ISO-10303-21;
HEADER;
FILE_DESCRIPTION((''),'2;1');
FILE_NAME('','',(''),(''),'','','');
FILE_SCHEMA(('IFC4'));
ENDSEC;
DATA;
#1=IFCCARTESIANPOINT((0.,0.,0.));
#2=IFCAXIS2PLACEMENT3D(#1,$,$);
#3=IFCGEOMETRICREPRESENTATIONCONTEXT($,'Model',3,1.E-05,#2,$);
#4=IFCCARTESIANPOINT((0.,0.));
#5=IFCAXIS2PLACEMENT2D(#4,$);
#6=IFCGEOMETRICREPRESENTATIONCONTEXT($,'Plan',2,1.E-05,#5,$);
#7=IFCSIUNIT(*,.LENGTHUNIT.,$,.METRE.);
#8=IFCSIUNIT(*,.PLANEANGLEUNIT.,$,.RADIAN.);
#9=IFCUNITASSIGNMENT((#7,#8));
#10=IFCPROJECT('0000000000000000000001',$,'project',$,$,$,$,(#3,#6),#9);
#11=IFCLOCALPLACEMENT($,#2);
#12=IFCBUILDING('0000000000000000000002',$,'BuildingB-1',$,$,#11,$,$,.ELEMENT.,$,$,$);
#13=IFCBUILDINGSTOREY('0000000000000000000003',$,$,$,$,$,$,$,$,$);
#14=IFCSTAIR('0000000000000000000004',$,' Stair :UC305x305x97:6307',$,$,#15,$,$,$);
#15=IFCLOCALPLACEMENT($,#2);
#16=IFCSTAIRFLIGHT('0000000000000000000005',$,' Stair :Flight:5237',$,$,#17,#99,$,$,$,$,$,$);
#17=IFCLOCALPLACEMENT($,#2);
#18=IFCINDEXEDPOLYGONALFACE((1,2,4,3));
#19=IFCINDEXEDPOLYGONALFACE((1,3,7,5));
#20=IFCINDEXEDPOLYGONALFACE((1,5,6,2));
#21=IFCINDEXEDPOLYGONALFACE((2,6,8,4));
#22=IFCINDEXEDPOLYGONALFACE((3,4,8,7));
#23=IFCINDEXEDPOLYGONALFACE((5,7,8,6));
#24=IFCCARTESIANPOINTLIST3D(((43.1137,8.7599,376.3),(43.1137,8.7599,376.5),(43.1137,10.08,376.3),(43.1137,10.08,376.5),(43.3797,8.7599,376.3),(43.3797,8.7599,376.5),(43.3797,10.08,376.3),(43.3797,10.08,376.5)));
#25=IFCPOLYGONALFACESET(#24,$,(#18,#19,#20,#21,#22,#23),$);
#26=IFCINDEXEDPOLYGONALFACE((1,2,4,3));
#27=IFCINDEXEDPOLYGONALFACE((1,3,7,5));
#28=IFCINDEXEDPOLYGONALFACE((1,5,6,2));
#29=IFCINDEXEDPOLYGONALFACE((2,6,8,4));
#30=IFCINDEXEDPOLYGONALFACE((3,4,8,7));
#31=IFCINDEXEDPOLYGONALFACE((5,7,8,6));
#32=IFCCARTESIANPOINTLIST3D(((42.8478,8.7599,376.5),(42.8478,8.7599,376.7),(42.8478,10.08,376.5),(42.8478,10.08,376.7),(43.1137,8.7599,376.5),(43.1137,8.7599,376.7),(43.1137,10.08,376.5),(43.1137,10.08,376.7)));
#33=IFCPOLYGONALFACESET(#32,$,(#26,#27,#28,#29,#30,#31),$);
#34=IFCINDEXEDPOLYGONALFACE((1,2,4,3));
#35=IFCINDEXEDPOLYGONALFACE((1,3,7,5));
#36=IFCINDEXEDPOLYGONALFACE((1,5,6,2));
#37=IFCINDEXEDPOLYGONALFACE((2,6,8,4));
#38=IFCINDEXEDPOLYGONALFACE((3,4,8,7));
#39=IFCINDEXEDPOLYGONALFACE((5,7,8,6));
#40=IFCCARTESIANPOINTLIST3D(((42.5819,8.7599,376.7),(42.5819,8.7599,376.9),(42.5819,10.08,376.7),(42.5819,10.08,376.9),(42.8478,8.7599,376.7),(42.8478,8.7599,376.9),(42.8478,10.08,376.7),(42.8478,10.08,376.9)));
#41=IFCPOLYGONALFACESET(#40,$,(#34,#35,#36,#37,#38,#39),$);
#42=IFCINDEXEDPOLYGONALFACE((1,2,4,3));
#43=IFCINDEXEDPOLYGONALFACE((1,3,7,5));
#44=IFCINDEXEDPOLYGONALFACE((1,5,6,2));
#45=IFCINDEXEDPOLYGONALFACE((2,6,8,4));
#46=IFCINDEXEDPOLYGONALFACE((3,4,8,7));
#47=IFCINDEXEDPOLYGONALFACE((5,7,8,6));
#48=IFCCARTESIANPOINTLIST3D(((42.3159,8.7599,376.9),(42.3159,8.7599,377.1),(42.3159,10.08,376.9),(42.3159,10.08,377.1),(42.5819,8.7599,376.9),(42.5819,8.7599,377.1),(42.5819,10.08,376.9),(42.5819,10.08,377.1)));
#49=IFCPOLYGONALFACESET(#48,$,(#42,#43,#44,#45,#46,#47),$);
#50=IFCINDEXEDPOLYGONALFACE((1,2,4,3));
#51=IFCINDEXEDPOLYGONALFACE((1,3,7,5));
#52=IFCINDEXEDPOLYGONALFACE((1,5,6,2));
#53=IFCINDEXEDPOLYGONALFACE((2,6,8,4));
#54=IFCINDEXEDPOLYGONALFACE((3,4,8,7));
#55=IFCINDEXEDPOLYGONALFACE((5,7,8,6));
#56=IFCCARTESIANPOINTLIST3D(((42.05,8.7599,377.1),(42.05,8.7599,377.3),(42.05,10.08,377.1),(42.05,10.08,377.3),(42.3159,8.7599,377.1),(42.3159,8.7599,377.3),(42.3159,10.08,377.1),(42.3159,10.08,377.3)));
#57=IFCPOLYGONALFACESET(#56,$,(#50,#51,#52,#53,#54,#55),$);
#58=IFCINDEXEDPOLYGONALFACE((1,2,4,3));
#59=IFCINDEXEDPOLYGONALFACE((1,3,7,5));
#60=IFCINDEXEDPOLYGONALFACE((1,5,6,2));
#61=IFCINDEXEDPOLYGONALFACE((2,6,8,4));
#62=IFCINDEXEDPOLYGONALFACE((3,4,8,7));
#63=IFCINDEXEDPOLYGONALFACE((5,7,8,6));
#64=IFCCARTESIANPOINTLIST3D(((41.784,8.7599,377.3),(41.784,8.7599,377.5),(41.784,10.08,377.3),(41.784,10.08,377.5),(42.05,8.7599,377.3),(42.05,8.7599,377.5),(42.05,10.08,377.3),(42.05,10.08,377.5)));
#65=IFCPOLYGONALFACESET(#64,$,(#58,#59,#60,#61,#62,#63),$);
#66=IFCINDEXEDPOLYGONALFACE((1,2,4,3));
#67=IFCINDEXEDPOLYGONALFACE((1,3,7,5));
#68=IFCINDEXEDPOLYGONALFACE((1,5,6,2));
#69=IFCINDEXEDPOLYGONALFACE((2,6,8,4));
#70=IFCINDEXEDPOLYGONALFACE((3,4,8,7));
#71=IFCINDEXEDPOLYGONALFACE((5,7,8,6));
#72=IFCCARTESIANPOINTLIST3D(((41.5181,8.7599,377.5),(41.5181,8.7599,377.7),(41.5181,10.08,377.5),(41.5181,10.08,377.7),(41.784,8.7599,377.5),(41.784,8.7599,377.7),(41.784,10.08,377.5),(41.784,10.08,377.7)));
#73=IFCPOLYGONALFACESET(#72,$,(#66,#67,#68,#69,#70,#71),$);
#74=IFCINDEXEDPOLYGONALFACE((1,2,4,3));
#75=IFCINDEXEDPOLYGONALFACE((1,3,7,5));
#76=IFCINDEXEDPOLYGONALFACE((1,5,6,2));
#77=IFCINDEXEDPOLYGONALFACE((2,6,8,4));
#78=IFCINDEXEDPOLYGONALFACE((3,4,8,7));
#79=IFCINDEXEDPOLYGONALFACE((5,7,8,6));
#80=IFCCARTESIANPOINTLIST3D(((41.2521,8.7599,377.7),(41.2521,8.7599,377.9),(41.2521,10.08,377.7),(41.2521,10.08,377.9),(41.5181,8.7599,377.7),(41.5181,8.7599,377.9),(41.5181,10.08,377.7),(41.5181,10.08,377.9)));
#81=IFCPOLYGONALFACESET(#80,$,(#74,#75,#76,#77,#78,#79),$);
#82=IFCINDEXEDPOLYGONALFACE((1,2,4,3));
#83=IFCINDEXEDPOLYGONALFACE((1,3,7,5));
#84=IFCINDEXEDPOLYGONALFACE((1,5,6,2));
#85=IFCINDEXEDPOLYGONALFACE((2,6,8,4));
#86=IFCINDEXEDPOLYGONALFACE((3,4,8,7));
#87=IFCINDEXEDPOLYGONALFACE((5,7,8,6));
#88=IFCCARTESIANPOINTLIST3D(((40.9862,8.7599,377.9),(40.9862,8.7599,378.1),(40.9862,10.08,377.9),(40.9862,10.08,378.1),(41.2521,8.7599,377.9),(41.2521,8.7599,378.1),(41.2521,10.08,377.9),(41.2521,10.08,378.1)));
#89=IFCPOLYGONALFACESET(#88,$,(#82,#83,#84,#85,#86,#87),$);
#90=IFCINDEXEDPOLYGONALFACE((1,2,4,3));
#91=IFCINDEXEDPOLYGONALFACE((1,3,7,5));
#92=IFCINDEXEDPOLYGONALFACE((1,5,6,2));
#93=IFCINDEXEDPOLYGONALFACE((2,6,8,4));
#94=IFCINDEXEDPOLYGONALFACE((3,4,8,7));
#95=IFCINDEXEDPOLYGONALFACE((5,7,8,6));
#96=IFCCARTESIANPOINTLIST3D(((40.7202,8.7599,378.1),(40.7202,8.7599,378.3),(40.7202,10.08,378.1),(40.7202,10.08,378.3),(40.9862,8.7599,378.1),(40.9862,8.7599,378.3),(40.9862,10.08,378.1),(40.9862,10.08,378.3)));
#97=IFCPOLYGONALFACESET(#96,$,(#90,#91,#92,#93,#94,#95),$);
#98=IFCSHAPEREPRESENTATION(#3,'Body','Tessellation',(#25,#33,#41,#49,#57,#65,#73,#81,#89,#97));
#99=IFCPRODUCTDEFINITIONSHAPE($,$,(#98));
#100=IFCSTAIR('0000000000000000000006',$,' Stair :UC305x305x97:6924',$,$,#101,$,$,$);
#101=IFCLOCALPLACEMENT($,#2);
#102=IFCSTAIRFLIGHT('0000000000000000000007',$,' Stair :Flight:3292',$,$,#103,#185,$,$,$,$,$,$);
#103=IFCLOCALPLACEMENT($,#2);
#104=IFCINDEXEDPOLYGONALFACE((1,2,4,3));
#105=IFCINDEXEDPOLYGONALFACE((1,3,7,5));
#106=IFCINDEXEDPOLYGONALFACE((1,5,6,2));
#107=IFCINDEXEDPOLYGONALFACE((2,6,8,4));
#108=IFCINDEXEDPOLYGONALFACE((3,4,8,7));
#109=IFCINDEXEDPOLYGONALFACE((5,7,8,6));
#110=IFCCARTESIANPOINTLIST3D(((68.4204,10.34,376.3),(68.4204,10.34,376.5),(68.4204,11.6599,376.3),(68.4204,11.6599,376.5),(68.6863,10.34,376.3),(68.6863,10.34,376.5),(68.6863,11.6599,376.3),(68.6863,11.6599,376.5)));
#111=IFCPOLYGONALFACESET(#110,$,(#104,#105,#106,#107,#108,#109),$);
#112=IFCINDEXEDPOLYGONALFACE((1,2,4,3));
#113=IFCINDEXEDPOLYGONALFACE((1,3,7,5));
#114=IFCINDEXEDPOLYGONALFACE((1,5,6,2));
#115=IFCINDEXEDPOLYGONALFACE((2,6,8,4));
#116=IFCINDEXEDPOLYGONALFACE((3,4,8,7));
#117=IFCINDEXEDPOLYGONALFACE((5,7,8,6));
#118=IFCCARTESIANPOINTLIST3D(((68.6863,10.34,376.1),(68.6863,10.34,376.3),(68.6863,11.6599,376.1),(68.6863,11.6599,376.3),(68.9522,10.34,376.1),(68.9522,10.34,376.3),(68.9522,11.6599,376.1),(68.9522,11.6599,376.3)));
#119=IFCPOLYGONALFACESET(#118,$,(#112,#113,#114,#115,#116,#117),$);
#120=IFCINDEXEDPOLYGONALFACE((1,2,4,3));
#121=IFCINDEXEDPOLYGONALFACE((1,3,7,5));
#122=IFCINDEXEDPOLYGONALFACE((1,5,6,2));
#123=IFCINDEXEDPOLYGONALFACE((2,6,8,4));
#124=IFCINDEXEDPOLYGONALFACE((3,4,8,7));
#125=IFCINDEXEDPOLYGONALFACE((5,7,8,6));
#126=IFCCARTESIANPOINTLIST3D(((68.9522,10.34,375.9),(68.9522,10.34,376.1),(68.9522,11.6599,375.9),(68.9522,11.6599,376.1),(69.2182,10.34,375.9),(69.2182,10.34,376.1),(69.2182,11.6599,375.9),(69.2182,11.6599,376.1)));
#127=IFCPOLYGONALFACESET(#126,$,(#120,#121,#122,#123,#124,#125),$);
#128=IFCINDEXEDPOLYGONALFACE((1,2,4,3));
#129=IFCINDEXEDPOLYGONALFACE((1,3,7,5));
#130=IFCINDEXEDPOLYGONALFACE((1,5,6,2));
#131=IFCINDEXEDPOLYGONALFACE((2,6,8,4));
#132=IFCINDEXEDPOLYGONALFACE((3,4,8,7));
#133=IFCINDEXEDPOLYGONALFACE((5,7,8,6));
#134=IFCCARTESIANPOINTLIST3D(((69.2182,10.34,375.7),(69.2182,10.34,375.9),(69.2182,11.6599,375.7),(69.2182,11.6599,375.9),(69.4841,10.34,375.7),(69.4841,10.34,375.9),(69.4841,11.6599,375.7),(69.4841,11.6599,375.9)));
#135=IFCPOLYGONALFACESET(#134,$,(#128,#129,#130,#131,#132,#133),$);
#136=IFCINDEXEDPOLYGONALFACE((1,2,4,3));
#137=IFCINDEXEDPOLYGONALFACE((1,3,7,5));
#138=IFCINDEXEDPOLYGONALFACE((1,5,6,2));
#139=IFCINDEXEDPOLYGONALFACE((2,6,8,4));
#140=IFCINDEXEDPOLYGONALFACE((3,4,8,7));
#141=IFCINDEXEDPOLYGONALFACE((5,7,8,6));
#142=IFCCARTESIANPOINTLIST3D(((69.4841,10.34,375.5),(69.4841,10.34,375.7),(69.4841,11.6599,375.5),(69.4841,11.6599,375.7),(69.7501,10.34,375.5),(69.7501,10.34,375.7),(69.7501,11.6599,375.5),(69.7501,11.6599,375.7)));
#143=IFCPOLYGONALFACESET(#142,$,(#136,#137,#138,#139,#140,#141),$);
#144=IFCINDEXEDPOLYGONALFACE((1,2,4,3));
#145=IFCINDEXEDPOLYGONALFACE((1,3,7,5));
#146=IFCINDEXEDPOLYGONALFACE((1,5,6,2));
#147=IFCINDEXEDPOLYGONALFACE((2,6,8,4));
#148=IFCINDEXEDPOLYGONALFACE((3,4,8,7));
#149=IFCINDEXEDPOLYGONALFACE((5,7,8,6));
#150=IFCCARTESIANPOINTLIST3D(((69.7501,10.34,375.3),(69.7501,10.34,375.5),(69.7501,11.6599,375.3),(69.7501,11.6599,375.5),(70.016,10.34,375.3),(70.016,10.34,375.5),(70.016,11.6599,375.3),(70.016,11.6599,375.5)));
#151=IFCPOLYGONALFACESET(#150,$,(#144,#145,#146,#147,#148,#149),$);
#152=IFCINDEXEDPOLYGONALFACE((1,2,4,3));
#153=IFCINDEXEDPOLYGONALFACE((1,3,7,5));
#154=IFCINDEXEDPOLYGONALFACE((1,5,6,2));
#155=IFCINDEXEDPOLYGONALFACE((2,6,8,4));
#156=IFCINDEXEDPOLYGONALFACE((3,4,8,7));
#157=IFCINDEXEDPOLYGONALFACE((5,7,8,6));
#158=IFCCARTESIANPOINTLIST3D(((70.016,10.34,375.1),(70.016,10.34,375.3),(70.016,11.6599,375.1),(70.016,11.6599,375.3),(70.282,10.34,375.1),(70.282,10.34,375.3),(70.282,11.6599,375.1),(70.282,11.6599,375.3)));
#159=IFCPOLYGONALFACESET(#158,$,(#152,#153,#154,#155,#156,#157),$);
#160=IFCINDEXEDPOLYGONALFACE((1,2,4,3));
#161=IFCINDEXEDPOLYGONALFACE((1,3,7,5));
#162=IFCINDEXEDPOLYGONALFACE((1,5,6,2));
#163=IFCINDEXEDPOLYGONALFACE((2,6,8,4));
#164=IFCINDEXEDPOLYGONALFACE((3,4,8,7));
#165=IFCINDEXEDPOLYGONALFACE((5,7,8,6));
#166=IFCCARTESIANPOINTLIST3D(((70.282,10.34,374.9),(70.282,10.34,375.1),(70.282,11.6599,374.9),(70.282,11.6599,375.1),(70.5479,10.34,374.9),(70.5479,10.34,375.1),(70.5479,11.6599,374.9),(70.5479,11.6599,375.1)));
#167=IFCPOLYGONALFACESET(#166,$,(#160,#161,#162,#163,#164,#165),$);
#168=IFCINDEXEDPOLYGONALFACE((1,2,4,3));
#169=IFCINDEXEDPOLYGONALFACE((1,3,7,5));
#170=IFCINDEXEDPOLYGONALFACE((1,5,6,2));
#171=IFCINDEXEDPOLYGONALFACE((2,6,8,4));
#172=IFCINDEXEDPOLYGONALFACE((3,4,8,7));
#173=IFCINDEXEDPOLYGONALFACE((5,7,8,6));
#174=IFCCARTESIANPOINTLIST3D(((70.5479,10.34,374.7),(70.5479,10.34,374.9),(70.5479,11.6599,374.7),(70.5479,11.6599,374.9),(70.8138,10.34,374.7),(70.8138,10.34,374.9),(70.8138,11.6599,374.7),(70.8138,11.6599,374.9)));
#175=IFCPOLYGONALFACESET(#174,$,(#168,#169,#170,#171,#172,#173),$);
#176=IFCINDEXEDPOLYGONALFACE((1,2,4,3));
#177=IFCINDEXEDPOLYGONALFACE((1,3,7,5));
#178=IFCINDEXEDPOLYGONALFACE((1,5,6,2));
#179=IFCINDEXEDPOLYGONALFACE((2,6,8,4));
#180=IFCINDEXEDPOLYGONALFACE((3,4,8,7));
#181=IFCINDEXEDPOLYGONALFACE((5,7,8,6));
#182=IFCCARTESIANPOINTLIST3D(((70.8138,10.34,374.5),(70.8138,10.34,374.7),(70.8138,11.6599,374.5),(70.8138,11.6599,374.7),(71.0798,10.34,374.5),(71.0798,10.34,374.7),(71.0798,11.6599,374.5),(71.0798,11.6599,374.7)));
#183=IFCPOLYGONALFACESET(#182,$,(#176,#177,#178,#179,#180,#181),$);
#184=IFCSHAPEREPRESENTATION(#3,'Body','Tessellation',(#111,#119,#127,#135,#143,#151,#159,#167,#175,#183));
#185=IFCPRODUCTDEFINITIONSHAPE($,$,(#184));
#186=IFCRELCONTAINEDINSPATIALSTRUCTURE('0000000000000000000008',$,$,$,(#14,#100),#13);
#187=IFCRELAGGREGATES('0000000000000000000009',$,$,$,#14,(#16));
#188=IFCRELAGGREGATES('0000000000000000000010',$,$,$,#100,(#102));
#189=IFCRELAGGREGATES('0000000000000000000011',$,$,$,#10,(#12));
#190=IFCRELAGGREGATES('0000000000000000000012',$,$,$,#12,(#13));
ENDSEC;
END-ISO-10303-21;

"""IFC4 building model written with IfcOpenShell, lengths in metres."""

from ifc_helpers import new_model, si_unit, frame, origin, origin_2d, place, context, project, spatial, polyline, outline, extrude, element, aggregate, save


model = new_model("IFC4")

# Units and contexts
model_context = context("Model", 3, precision=1e-05, world=origin())
plan_context = context("Plan", 2, precision=1e-05, world=origin_2d())
ifc_project = project(units=[si_unit("LENGTHUNIT", "METRE"), si_unit("PLANEANGLEUNIT", "RADIAN")], contexts=[model_context, plan_context])

# Building, storey
building_placement = place(None, origin())
building = spatial("IfcBuilding", under=ifc_project, at=building_placement, Name="BuildingB-1", CompositionType="ELEMENT")
storey = spatial("IfcBuildingStorey", under=building)

# Stairs, stair flights
stair_1 = element("IfcStair", 1, inside=storey, Name=" Stair :UC305x305x97:6307")
stair_flight_1 = element("IfcStairFlight", 2, Name=" Stair :Flight:5237", context=model_context, shape_type="SweptSolid", body=[
    extrude(outline(polyline([(43.1137, 8.7599, 376.5), (43.1137, 10.08, 376.5), (43.3797, 10.08, 376.5), (43.3797, 8.7599, 376.5), (43.1137, 8.7599, 376.5)])), origin(), (0.0, 0.0, -1.0), 0.2),
    extrude(outline(polyline([(42.8478, 8.7599, 376.5), (42.8478, 10.08, 376.5), (43.1137, 10.08, 376.5), (43.1137, 8.7599, 376.5), (42.8478, 8.7599, 376.5)])), frame((0.0, 0.0, 0.2)), (0.0, 0.0, -1.0), 0.2),
    extrude(outline(polyline([(42.5819, 8.7599, 376.5), (42.5819, 10.08, 376.5), (42.8478, 10.08, 376.5), (42.8478, 8.7599, 376.5), (42.5819, 8.7599, 376.5)])), frame((0.0, 0.0, 0.4)), (0.0, 0.0, -1.0), 0.2),
    extrude(outline(polyline([(42.3159, 8.7599, 376.5), (42.3159, 10.08, 376.5), (42.5819, 10.08, 376.5), (42.5819, 8.7599, 376.5), (42.3159, 8.7599, 376.5)])), frame((0.0, 0.0, 0.6)), (0.0, 0.0, -1.0), 0.2),
    extrude(outline(polyline([(42.05, 8.7599, 376.5), (42.05, 10.08, 376.5), (42.3159, 10.08, 376.5), (42.3159, 8.7599, 376.5), (42.05, 8.7599, 376.5)])), frame((0.0, 0.0, 0.8)), (0.0, 0.0, -1.0), 0.2),
    extrude(outline(polyline([(41.784, 8.7599, 376.5), (41.784, 10.08, 376.5), (42.05, 10.08, 376.5), (42.05, 8.7599, 376.5), (41.784, 8.7599, 376.5)])), frame((0.0, 0.0, 1.0)), (0.0, 0.0, -1.0), 0.2),
    extrude(outline(polyline([(41.5181, 8.7599, 376.5), (41.5181, 10.08, 376.5), (41.784, 10.08, 376.5), (41.784, 8.7599, 376.5), (41.5181, 8.7599, 376.5)])), frame((0.0, 0.0, 1.2)), (0.0, 0.0, -1.0), 0.2),
    extrude(outline(polyline([(41.2521, 8.7599, 376.5), (41.2521, 10.08, 376.5), (41.5181, 10.08, 376.5), (41.5181, 8.7599, 376.5), (41.2521, 8.7599, 376.5)])), frame((0.0, 0.0, 1.4)), (0.0, 0.0, -1.0), 0.2),
    extrude(outline(polyline([(40.9862, 8.7599, 376.5), (40.9862, 10.08, 376.5), (41.2521, 10.08, 376.5), (41.2521, 8.7599, 376.5), (40.9862, 8.7599, 376.5)])), frame((0.0, 0.0, 1.6)), (0.0, 0.0, -1.0), 0.2),
    extrude(outline(polyline([(40.7202, 8.7599, 376.5), (40.7202, 10.08, 376.5), (40.9862, 10.08, 376.5), (40.9862, 8.7599, 376.5), (40.7202, 8.7599, 376.5)])), frame((0.0, 0.0, 1.8)), (0.0, 0.0, -1.0), 0.2),
])
aggregate(stair_1, [stair_flight_1])
stair_2 = element("IfcStair", 3, inside=storey, Name=" Stair :UC305x305x97:6924")
stair_flight_2 = element("IfcStairFlight", 4, Name=" Stair :Flight:3292", context=model_context, shape_type="SweptSolid", body=[
    extrude(outline(polyline([(68.6863, 11.6599, 376.5), (68.6863, 10.34, 376.5), (68.4204, 10.34, 376.5), (68.4204, 11.6599, 376.5), (68.6863, 11.6599, 376.5)])), origin(), (0.0, 0.0, -1.0), 0.2),
    extrude(outline(polyline([(68.9522, 11.6599, 376.5), (68.9522, 10.34, 376.5), (68.6863, 10.34, 376.5), (68.6863, 11.6599, 376.5), (68.9522, 11.6599, 376.5)])), frame((0.0, 0.0, -0.2)), (0.0, 0.0, -1.0), 0.2),
    extrude(outline(polyline([(69.2182, 11.6599, 376.5), (69.2182, 10.34, 376.5), (68.9522, 10.34, 376.5), (68.9522, 11.6599, 376.5), (69.2182, 11.6599, 376.5)])), frame((0.0, 0.0, -0.4)), (0.0, 0.0, -1.0), 0.2),
    extrude(outline(polyline([(69.4841, 11.6599, 376.5), (69.4841, 10.34, 376.5), (69.2182, 10.34, 376.5), (69.2182, 11.6599, 376.5), (69.4841, 11.6599, 376.5)])), frame((0.0, 0.0, -0.6)), (0.0, 0.0, -1.0), 0.2),
    extrude(outline(polyline([(69.7501, 11.6599, 376.5), (69.7501, 10.34, 376.5), (69.4841, 10.34, 376.5), (69.4841, 11.6599, 376.5), (69.7501, 11.6599, 376.5)])), frame((0.0, 0.0, -0.8)), (0.0, 0.0, -1.0), 0.2),
    extrude(outline(polyline([(70.016, 11.6599, 376.5), (70.016, 10.34, 376.5), (69.7501, 10.34, 376.5), (69.7501, 11.6599, 376.5), (70.016, 11.6599, 376.5)])), frame((0.0, 0.0, -1.0)), (0.0, 0.0, -1.0), 0.2),
    extrude(outline(polyline([(70.282, 11.6599, 376.5), (70.282, 10.34, 376.5), (70.016, 10.34, 376.5), (70.016, 11.6599, 376.5), (70.282, 11.6599, 376.5)])), frame((0.0, 0.0, -1.2)), (0.0, 0.0, -1.0), 0.2),
    extrude(outline(polyline([(70.5479, 11.6599, 376.5), (70.5479, 10.34, 376.5), (70.282, 10.34, 376.5), (70.282, 11.6599, 376.5), (70.5479, 11.6599, 376.5)])), frame((0.0, 0.0, -1.4)), (0.0, 0.0, -1.0), 0.2),
    extrude(outline(polyline([(70.8138, 11.6599, 376.5), (70.8138, 10.34, 376.5), (70.5479, 10.34, 376.5), (70.5479, 11.6599, 376.5), (70.8138, 11.6599, 376.5)])), frame((0.0, 0.0, -1.6)), (0.0, 0.0, -1.0), 0.2),
    extrude(outline(polyline([(71.0798, 11.6599, 376.5), (71.0798, 10.34, 376.5), (70.8138, 10.34, 376.5), (70.8138, 11.6599, 376.5), (71.0798, 11.6599, 376.5)])), frame((0.0, 0.0, -1.8)), (0.0, 0.0, -1.0), 0.2),
])
aggregate(stair_2, [stair_flight_2])

save(model, "model.ifc")
